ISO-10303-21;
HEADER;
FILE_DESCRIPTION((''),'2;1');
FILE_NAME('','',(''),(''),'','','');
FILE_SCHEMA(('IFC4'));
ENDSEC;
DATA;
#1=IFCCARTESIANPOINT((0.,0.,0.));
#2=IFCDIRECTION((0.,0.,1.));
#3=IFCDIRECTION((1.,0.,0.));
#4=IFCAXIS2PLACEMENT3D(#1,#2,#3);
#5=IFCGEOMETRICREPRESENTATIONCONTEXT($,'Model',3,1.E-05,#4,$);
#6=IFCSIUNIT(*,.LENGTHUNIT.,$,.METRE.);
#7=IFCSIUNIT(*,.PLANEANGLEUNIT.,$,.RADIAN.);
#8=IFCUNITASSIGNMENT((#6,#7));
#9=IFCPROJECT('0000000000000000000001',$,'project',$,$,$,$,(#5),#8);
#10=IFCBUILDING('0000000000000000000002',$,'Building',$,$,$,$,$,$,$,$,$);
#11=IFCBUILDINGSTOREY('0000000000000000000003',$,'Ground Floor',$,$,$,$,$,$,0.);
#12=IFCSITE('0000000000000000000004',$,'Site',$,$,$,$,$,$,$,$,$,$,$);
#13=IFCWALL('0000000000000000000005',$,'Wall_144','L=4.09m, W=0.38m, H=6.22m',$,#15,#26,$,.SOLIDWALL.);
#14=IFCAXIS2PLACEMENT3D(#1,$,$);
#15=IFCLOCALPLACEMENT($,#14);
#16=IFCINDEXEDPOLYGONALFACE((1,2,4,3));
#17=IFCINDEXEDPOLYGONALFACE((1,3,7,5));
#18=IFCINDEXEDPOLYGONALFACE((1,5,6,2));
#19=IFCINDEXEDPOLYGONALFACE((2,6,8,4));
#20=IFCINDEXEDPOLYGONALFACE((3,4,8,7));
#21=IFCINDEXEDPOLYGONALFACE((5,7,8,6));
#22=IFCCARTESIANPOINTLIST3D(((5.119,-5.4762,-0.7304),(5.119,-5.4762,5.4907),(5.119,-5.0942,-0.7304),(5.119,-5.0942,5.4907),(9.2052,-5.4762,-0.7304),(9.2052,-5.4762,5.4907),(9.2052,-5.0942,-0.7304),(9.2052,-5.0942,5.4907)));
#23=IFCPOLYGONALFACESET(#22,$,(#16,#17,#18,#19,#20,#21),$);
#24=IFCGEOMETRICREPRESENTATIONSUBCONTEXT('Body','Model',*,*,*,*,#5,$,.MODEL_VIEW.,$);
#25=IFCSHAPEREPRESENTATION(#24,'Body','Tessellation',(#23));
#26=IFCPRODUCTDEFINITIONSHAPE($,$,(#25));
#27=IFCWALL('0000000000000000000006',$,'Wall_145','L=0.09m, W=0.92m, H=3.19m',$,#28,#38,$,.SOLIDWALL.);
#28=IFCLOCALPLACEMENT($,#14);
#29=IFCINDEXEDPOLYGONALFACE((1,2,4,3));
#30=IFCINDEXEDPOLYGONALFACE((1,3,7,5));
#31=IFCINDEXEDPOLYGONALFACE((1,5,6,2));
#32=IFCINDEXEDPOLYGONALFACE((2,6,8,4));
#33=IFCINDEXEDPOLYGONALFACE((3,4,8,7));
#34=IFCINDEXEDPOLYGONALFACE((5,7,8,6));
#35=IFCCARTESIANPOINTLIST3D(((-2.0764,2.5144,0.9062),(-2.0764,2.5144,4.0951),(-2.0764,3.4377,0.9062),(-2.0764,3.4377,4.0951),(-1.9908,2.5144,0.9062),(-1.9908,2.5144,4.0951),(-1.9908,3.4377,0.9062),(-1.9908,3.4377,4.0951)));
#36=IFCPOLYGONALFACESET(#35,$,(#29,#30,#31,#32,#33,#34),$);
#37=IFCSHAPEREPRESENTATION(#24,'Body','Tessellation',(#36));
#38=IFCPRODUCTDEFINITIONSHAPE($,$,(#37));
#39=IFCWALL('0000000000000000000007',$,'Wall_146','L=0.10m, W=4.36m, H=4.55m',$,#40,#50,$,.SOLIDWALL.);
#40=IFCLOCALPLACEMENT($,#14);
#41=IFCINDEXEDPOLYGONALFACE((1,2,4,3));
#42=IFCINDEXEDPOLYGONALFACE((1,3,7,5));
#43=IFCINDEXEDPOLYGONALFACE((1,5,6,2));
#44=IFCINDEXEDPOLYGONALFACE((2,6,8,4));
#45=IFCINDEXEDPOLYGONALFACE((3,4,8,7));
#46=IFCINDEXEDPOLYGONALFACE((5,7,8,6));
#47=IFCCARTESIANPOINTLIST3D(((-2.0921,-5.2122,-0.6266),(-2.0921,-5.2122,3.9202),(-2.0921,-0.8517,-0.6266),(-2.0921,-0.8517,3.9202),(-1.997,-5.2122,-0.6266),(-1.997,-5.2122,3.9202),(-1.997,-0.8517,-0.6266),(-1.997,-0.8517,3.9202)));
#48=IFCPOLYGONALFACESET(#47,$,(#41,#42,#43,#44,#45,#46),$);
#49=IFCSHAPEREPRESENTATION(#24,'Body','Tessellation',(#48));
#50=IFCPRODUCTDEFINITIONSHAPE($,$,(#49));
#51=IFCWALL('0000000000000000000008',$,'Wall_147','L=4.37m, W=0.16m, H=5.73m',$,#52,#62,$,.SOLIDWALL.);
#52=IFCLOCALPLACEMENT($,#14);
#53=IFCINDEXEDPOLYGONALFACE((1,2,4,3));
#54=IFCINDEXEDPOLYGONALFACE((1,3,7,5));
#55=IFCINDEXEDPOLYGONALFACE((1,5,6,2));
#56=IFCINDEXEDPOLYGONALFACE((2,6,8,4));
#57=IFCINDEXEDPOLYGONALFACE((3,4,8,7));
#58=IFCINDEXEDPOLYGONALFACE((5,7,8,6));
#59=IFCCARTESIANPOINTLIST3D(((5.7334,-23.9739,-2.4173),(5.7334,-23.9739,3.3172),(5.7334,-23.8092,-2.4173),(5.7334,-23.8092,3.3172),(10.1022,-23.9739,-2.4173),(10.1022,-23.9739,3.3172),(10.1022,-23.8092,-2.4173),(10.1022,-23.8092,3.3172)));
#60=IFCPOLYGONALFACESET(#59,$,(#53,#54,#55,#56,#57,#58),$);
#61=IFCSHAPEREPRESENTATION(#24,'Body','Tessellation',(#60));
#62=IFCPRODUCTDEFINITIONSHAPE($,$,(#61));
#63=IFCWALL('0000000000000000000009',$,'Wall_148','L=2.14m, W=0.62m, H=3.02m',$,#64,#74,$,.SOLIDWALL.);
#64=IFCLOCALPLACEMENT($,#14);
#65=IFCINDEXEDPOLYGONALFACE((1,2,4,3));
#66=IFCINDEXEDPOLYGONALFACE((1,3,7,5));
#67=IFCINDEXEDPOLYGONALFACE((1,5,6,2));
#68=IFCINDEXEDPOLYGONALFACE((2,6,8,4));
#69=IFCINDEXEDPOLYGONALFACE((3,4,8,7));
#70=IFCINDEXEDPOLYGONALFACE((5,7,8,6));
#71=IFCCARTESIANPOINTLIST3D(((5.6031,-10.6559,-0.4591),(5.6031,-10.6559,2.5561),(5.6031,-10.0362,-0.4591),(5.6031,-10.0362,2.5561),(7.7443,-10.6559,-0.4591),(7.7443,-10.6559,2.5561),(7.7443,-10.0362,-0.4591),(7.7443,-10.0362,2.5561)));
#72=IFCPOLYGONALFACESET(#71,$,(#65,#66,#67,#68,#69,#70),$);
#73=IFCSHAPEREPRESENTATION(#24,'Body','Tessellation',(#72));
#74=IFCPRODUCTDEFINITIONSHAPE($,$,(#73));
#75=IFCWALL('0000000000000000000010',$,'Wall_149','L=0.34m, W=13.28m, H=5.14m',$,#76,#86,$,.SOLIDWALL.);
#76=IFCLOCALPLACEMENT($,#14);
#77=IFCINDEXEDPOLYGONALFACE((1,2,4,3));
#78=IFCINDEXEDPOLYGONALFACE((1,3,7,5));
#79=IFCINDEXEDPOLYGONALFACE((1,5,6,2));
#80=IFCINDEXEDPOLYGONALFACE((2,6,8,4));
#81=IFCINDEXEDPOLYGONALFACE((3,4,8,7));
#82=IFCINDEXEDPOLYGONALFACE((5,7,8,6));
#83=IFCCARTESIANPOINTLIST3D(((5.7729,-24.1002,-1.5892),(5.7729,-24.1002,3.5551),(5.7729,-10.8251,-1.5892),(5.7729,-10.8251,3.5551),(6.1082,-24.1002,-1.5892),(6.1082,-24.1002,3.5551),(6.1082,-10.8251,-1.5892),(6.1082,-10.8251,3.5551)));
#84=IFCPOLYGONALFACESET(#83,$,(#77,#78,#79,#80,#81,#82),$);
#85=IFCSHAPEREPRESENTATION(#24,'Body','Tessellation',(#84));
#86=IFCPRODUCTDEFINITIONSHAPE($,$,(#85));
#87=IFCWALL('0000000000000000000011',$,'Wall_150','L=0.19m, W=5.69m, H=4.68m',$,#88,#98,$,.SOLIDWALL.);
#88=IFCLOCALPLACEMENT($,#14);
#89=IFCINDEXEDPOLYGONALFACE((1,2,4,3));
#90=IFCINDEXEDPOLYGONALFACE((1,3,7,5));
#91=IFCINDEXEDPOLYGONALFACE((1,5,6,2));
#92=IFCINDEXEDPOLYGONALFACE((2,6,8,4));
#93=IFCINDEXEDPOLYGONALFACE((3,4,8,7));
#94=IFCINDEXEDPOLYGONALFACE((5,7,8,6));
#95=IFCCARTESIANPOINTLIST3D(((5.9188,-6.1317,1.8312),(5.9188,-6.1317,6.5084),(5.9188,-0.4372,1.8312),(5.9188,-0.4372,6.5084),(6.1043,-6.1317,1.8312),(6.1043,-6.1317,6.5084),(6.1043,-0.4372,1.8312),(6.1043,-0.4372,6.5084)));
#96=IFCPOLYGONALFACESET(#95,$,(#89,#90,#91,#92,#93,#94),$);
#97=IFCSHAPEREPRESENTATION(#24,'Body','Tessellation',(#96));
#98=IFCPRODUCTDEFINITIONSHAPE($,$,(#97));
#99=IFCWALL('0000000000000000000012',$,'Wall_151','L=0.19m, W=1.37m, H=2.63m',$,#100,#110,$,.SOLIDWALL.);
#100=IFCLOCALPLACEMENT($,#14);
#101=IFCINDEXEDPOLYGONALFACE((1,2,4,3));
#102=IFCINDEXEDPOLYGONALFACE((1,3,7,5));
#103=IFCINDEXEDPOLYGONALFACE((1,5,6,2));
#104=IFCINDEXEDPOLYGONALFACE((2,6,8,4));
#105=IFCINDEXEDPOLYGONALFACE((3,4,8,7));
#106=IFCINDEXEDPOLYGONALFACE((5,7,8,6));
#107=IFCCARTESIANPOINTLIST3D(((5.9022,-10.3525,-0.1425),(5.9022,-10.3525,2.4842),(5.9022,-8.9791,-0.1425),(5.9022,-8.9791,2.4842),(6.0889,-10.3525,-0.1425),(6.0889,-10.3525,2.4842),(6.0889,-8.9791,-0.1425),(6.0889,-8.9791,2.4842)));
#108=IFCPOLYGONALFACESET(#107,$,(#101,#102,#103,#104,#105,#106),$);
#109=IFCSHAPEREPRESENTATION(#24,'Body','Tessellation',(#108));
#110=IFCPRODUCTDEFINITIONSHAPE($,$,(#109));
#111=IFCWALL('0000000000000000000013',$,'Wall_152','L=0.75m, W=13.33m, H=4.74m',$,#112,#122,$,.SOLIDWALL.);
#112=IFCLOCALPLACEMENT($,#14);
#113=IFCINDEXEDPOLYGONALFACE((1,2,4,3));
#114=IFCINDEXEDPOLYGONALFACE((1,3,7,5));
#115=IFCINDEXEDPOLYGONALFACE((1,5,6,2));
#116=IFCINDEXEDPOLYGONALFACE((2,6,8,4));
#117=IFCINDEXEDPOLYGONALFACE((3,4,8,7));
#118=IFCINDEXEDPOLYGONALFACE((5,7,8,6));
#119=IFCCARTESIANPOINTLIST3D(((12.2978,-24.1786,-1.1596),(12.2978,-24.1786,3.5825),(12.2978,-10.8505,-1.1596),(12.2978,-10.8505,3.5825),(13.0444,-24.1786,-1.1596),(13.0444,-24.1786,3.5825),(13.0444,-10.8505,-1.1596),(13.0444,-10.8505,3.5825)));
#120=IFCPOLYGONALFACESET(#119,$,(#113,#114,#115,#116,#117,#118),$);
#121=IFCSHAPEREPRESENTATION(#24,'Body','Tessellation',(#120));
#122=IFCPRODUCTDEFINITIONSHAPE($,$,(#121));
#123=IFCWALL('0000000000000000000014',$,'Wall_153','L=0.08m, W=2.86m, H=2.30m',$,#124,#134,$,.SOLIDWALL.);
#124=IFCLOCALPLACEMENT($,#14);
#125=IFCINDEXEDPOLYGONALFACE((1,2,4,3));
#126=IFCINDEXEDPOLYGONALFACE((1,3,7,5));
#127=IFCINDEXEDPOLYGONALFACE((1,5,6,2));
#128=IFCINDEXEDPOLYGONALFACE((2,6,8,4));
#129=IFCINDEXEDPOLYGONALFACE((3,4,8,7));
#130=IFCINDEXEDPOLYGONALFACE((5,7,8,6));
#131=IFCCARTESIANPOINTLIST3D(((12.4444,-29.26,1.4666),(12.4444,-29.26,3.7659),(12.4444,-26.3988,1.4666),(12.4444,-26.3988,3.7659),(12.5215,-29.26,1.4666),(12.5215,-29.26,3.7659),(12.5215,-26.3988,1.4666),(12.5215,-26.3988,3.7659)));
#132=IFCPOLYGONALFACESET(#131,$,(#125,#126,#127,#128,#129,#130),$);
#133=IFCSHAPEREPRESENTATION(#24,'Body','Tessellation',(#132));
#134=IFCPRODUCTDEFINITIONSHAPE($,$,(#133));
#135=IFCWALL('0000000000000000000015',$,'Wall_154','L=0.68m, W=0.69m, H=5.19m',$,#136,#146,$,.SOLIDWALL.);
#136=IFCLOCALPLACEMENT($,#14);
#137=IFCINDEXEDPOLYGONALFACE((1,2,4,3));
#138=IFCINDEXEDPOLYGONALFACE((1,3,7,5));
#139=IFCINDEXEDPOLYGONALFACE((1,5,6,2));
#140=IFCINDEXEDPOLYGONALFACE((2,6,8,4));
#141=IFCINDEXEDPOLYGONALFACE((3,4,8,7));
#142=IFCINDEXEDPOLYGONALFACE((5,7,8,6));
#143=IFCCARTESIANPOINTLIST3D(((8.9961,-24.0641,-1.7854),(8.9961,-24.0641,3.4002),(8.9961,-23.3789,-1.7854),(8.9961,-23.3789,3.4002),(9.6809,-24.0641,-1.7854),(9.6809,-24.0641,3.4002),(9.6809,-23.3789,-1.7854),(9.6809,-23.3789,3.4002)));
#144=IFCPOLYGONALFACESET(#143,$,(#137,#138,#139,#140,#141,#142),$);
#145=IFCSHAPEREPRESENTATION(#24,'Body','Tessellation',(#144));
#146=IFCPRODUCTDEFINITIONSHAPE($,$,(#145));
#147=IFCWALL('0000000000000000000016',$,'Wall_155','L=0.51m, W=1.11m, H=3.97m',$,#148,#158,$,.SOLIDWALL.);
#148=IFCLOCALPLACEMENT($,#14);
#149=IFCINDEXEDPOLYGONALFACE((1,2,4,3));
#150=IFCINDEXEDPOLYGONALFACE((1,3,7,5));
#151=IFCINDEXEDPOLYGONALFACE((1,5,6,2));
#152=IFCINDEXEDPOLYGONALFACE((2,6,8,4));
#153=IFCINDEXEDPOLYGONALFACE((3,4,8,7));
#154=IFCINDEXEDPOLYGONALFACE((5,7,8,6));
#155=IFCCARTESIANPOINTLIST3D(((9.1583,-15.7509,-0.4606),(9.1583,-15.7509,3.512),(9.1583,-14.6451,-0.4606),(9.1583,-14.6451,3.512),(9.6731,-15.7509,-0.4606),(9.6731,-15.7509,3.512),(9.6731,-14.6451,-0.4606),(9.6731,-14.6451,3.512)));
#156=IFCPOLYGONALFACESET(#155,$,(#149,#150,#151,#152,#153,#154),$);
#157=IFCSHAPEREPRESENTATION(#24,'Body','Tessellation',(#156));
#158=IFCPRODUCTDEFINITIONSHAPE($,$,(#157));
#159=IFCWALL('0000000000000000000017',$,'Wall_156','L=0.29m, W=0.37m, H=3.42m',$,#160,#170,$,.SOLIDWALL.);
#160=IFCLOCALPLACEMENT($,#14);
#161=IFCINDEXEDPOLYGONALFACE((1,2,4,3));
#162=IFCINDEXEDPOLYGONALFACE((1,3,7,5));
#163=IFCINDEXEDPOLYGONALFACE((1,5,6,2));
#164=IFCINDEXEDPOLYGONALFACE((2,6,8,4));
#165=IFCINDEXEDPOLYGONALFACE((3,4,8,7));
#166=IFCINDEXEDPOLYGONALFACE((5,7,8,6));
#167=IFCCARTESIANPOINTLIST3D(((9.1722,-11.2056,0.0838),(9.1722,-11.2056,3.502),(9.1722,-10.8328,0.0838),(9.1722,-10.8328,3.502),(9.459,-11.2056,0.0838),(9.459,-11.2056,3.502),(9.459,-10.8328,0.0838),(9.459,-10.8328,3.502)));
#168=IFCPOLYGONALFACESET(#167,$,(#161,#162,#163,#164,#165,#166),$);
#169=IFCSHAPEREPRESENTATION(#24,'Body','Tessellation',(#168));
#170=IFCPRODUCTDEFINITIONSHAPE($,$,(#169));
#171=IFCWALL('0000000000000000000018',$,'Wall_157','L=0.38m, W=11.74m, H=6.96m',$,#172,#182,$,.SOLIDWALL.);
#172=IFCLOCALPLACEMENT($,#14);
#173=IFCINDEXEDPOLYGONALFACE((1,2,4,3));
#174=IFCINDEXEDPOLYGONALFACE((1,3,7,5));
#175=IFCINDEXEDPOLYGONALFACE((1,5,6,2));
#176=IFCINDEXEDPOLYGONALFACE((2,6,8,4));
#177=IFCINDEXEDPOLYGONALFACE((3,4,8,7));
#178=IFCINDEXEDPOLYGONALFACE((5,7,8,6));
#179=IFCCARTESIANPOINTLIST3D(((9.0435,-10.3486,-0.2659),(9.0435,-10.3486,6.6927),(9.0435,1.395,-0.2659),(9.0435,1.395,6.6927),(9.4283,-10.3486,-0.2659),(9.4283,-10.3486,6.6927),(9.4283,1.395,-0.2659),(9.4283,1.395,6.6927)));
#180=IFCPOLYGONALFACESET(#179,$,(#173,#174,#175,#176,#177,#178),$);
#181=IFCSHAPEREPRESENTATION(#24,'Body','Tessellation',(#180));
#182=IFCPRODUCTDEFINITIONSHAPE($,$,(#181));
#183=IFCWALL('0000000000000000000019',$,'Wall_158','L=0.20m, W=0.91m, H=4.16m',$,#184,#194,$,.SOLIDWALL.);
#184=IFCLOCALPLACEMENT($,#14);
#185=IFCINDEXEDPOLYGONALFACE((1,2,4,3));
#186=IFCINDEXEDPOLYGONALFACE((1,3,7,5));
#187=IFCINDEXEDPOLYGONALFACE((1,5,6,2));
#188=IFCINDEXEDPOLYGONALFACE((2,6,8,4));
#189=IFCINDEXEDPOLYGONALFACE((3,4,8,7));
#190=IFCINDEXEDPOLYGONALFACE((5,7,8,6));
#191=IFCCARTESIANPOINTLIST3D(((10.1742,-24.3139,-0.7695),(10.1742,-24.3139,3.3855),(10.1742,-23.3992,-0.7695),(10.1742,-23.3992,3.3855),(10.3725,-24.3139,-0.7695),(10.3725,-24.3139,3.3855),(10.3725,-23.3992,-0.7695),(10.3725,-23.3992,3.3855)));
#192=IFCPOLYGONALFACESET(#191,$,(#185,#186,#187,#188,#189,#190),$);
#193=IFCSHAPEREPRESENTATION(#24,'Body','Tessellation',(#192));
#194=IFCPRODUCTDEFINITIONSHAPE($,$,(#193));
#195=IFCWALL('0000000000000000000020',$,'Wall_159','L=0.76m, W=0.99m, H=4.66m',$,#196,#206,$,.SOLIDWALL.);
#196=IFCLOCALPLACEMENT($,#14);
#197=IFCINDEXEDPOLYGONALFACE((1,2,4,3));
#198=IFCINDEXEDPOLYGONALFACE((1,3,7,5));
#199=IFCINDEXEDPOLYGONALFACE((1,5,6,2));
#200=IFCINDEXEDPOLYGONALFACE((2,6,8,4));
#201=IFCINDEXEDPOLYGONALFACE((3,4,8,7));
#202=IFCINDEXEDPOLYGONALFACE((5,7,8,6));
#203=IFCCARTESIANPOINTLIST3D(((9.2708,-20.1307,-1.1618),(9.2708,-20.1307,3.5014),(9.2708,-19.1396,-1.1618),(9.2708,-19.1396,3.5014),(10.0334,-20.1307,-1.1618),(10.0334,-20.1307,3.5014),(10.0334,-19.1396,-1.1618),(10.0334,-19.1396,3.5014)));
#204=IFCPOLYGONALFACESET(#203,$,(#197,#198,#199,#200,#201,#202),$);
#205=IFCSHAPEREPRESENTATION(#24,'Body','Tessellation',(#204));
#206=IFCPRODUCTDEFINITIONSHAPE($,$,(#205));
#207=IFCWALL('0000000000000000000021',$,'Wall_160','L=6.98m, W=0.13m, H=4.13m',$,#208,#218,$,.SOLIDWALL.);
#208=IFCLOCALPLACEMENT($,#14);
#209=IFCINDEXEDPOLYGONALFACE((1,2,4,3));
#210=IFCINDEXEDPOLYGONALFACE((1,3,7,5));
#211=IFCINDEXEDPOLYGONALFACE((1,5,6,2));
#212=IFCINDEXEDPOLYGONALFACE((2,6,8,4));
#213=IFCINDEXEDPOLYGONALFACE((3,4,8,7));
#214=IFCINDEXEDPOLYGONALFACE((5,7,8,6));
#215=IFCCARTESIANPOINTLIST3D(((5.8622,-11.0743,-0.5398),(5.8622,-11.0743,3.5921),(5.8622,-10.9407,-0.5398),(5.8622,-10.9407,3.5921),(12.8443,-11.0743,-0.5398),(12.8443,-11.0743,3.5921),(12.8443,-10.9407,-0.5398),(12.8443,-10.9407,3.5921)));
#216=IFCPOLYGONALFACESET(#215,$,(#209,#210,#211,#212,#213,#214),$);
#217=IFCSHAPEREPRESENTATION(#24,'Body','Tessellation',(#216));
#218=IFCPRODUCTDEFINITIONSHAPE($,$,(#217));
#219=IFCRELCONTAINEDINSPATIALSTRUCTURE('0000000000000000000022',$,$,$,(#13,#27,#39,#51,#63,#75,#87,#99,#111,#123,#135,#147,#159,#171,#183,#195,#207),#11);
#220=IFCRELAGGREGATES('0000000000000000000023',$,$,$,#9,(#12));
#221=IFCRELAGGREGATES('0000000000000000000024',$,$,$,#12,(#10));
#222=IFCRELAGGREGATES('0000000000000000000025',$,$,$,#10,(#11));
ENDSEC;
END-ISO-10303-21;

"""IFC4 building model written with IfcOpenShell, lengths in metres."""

from ifc_helpers import new_model, si_unit, frame, origin_with_axes, origin_2d, context, subcontext, project, spatial, rectangle, extrude, element, save


model = new_model("IFC4")

# Units and contexts
model_context = context("Model", 3, precision=1e-05, world=origin_with_axes())
body_context = subcontext(model_context, "Body", "Model", "MODEL_VIEW")
ifc_project = project(units=[si_unit("LENGTHUNIT", "METRE"), si_unit("PLANEANGLEUNIT", "RADIAN")], contexts=[model_context])

# Site, building, storey
site = spatial("IfcSite", under=ifc_project, Name="Site")
building = spatial("IfcBuilding", under=site, Name="Building")
storey = spatial("IfcBuildingStorey", under=building, Name="Ground Floor", Elevation=0.0)

# Walls
element("IfcWall", 1, inside=storey, Name="Wall_144", Description="L=4.09m, W=0.38m, H=6.22m", PredefinedType="SOLIDWALL", context=body_context, shape_type="SweptSolid", body=[
    extrude(rectangle(XDim=4.0862, YDim=0.382, at=origin_2d()), frame((7.1621, -5.2852, -0.7304), z_axis=(0.0, 0.0, 1.0), x_axis=(1.0, 0.0, 0.0)), (0.0, 0.0, 1.0), 6.221),
])
element("IfcWall", 2, inside=storey, Name="Wall_145", Description="L=0.09m, W=0.92m, H=3.19m", PredefinedType="SOLIDWALL", context=body_context, shape_type="SweptSolid", body=[
    extrude(rectangle(XDim=0.0856, YDim=0.9233, at=origin_2d()), frame((-2.0336, 2.9761, 0.9062), z_axis=(0.0, 0.0, 1.0), x_axis=(1.0, 0.0, 0.0)), (0.0, 0.0, 1.0), 3.1889),
])
element("IfcWall", 3, inside=storey, Name="Wall_146", Description="L=0.10m, W=4.36m, H=4.55m", PredefinedType="SOLIDWALL", context=body_context, shape_type="SweptSolid", body=[
    extrude(rectangle(XDim=0.0952, YDim=4.3605, at=origin_2d()), frame((-2.0445, -3.0319, -0.6266), z_axis=(0.0, 0.0, 1.0), x_axis=(1.0, 0.0, 0.0)), (0.0, 0.0, 1.0), 4.5468),
])
element("IfcWall", 4, inside=storey, Name="Wall_147", Description="L=4.37m, W=0.16m, H=5.73m", PredefinedType="SOLIDWALL", context=body_context, shape_type="SweptSolid", body=[
    extrude(rectangle(XDim=4.3689, YDim=0.1647, at=origin_2d()), frame((7.9178, -23.8915, -2.4173), z_axis=(0.0, 0.0, 1.0), x_axis=(1.0, 0.0, 0.0)), (0.0, 0.0, 1.0), 5.7345),
])
element("IfcWall", 5, inside=storey, Name="Wall_148", Description="L=2.14m, W=0.62m, H=3.02m", PredefinedType="SOLIDWALL", context=body_context, shape_type="SweptSolid", body=[
    extrude(rectangle(XDim=2.1412, YDim=0.6196, at=origin_2d()), frame((6.6737, -10.3461, -0.4591), z_axis=(0.0, 0.0, 1.0), x_axis=(1.0, 0.0, 0.0)), (0.0, 0.0, 1.0), 3.0152),
])
element("IfcWall", 6, inside=storey, Name="Wall_149", Description="L=0.34m, W=13.28m, H=5.14m", PredefinedType="SOLIDWALL", context=body_context, shape_type="SweptSolid", body=[
    extrude(rectangle(XDim=0.3353, YDim=13.2751, at=origin_2d()), frame((5.9405, -17.4627, -1.5892), z_axis=(0.0, 0.0, 1.0), x_axis=(1.0, 0.0, 0.0)), (0.0, 0.0, 1.0), 5.1443),
])
element("IfcWall", 7, inside=storey, Name="Wall_150", Description="L=0.19m, W=5.69m, H=4.68m", PredefinedType="SOLIDWALL", context=body_context, shape_type="SweptSolid", body=[
    extrude(rectangle(XDim=0.1855, YDim=5.6945, at=origin_2d()), frame((6.0116, -3.2845, 1.8312), z_axis=(0.0, 0.0, 1.0), x_axis=(1.0, 0.0, 0.0)), (0.0, 0.0, 1.0), 4.6772),
])
element("IfcWall", 8, inside=storey, Name="Wall_151", Description="L=0.19m, W=1.37m, H=2.63m", PredefinedType="SOLIDWALL", context=body_context, shape_type="SweptSolid", body=[
    extrude(rectangle(XDim=0.1867, YDim=1.3734, at=origin_2d()), frame((5.9956, -9.6658, -0.1425), z_axis=(0.0, 0.0, 1.0), x_axis=(1.0, 0.0, 0.0)), (0.0, 0.0, 1.0), 2.6267),
])
element("IfcWall", 9, inside=storey, Name="Wall_152", Description="L=0.75m, W=13.33m, H=4.74m", PredefinedType="SOLIDWALL", context=body_context, shape_type="SweptSolid", body=[
    extrude(rectangle(XDim=0.7465, YDim=13.3281, at=origin_2d()), frame((12.6711, -17.5145, -1.1596), z_axis=(0.0, 0.0, 1.0), x_axis=(1.0, 0.0, 0.0)), (0.0, 0.0, 1.0), 4.7421),
])
element("IfcWall", 10, inside=storey, Name="Wall_153", Description="L=0.08m, W=2.86m, H=2.30m", PredefinedType="SOLIDWALL", context=body_context, shape_type="SweptSolid", body=[
    extrude(rectangle(XDim=0.0771, YDim=2.8612, at=origin_2d()), frame((12.4829, -27.8294, 1.4666), z_axis=(0.0, 0.0, 1.0), x_axis=(1.0, 0.0, 0.0)), (0.0, 0.0, 1.0), 2.2993),
])
element("IfcWall", 11, inside=storey, Name="Wall_154", Description="L=0.68m, W=0.69m, H=5.19m", PredefinedType="SOLIDWALL", context=body_context, shape_type="SweptSolid", body=[
    extrude(rectangle(XDim=0.6848, YDim=0.6852, at=origin_2d()), frame((9.3385, -23.7215, -1.7854), z_axis=(0.0, 0.0, 1.0), x_axis=(1.0, 0.0, 0.0)), (0.0, 0.0, 1.0), 5.1856),
])
element("IfcWall", 12, inside=storey, Name="Wall_155", Description="L=0.51m, W=1.11m, H=3.97m", PredefinedType="SOLIDWALL", context=body_context, shape_type="SweptSolid", body=[
    extrude(rectangle(XDim=0.5147, YDim=1.1058, at=origin_2d()), frame((9.4157, -15.198, -0.4606), z_axis=(0.0, 0.0, 1.0), x_axis=(1.0, 0.0, 0.0)), (0.0, 0.0, 1.0), 3.9726),
])
element("IfcWall", 13, inside=storey, Name="Wall_156", Description="L=0.29m, W=0.37m, H=3.42m", PredefinedType="SOLIDWALL", context=body_context, shape_type="SweptSolid", body=[
    extrude(rectangle(XDim=0.2869, YDim=0.3728, at=origin_2d()), frame((9.3156, -11.0192, 0.0838), z_axis=(0.0, 0.0, 1.0), x_axis=(1.0, 0.0, 0.0)), (0.0, 0.0, 1.0), 3.4182),
])
element("IfcWall", 14, inside=storey, Name="Wall_157", Description="L=0.38m, W=11.74m, H=6.96m", PredefinedType="SOLIDWALL", context=body_context, shape_type="SweptSolid", body=[
    extrude(rectangle(XDim=0.3848, YDim=11.7436, at=origin_2d()), frame((9.2359, -4.4768, -0.2659), z_axis=(0.0, 0.0, 1.0), x_axis=(1.0, 0.0, 0.0)), (0.0, 0.0, 1.0), 6.9586),
])
element("IfcWall", 15, inside=storey, Name="Wall_158", Description="L=0.20m, W=0.91m, H=4.16m", PredefinedType="SOLIDWALL", context=body_context, shape_type="SweptSolid", body=[
    extrude(rectangle(XDim=0.1983, YDim=0.9148, at=origin_2d()), frame((10.2733, -23.8565, -0.7695), z_axis=(0.0, 0.0, 1.0), x_axis=(1.0, 0.0, 0.0)), (0.0, 0.0, 1.0), 4.155),
])
element("IfcWall", 16, inside=storey, Name="Wall_159", Description="L=0.76m, W=0.99m, H=4.66m", PredefinedType="SOLIDWALL", context=body_context, shape_type="SweptSolid", body=[
    extrude(rectangle(XDim=0.7626, YDim=0.9911, at=origin_2d()), frame((9.6521, -19.6352, -1.1618), z_axis=(0.0, 0.0, 1.0), x_axis=(1.0, 0.0, 0.0)), (0.0, 0.0, 1.0), 4.6632),
])
element("IfcWall", 17, inside=storey, Name="Wall_160", Description="L=6.98m, W=0.13m, H=4.13m", PredefinedType="SOLIDWALL", context=body_context, shape_type="SweptSolid", body=[
    extrude(rectangle(XDim=6.9821, YDim=0.1337, at=origin_2d()), frame((9.3532, -11.0075, -0.5398), z_axis=(0.0, 0.0, 1.0), x_axis=(1.0, 0.0, 0.0)), (0.0, 0.0, 1.0), 4.132),
])

save(model, "model.ifc")
